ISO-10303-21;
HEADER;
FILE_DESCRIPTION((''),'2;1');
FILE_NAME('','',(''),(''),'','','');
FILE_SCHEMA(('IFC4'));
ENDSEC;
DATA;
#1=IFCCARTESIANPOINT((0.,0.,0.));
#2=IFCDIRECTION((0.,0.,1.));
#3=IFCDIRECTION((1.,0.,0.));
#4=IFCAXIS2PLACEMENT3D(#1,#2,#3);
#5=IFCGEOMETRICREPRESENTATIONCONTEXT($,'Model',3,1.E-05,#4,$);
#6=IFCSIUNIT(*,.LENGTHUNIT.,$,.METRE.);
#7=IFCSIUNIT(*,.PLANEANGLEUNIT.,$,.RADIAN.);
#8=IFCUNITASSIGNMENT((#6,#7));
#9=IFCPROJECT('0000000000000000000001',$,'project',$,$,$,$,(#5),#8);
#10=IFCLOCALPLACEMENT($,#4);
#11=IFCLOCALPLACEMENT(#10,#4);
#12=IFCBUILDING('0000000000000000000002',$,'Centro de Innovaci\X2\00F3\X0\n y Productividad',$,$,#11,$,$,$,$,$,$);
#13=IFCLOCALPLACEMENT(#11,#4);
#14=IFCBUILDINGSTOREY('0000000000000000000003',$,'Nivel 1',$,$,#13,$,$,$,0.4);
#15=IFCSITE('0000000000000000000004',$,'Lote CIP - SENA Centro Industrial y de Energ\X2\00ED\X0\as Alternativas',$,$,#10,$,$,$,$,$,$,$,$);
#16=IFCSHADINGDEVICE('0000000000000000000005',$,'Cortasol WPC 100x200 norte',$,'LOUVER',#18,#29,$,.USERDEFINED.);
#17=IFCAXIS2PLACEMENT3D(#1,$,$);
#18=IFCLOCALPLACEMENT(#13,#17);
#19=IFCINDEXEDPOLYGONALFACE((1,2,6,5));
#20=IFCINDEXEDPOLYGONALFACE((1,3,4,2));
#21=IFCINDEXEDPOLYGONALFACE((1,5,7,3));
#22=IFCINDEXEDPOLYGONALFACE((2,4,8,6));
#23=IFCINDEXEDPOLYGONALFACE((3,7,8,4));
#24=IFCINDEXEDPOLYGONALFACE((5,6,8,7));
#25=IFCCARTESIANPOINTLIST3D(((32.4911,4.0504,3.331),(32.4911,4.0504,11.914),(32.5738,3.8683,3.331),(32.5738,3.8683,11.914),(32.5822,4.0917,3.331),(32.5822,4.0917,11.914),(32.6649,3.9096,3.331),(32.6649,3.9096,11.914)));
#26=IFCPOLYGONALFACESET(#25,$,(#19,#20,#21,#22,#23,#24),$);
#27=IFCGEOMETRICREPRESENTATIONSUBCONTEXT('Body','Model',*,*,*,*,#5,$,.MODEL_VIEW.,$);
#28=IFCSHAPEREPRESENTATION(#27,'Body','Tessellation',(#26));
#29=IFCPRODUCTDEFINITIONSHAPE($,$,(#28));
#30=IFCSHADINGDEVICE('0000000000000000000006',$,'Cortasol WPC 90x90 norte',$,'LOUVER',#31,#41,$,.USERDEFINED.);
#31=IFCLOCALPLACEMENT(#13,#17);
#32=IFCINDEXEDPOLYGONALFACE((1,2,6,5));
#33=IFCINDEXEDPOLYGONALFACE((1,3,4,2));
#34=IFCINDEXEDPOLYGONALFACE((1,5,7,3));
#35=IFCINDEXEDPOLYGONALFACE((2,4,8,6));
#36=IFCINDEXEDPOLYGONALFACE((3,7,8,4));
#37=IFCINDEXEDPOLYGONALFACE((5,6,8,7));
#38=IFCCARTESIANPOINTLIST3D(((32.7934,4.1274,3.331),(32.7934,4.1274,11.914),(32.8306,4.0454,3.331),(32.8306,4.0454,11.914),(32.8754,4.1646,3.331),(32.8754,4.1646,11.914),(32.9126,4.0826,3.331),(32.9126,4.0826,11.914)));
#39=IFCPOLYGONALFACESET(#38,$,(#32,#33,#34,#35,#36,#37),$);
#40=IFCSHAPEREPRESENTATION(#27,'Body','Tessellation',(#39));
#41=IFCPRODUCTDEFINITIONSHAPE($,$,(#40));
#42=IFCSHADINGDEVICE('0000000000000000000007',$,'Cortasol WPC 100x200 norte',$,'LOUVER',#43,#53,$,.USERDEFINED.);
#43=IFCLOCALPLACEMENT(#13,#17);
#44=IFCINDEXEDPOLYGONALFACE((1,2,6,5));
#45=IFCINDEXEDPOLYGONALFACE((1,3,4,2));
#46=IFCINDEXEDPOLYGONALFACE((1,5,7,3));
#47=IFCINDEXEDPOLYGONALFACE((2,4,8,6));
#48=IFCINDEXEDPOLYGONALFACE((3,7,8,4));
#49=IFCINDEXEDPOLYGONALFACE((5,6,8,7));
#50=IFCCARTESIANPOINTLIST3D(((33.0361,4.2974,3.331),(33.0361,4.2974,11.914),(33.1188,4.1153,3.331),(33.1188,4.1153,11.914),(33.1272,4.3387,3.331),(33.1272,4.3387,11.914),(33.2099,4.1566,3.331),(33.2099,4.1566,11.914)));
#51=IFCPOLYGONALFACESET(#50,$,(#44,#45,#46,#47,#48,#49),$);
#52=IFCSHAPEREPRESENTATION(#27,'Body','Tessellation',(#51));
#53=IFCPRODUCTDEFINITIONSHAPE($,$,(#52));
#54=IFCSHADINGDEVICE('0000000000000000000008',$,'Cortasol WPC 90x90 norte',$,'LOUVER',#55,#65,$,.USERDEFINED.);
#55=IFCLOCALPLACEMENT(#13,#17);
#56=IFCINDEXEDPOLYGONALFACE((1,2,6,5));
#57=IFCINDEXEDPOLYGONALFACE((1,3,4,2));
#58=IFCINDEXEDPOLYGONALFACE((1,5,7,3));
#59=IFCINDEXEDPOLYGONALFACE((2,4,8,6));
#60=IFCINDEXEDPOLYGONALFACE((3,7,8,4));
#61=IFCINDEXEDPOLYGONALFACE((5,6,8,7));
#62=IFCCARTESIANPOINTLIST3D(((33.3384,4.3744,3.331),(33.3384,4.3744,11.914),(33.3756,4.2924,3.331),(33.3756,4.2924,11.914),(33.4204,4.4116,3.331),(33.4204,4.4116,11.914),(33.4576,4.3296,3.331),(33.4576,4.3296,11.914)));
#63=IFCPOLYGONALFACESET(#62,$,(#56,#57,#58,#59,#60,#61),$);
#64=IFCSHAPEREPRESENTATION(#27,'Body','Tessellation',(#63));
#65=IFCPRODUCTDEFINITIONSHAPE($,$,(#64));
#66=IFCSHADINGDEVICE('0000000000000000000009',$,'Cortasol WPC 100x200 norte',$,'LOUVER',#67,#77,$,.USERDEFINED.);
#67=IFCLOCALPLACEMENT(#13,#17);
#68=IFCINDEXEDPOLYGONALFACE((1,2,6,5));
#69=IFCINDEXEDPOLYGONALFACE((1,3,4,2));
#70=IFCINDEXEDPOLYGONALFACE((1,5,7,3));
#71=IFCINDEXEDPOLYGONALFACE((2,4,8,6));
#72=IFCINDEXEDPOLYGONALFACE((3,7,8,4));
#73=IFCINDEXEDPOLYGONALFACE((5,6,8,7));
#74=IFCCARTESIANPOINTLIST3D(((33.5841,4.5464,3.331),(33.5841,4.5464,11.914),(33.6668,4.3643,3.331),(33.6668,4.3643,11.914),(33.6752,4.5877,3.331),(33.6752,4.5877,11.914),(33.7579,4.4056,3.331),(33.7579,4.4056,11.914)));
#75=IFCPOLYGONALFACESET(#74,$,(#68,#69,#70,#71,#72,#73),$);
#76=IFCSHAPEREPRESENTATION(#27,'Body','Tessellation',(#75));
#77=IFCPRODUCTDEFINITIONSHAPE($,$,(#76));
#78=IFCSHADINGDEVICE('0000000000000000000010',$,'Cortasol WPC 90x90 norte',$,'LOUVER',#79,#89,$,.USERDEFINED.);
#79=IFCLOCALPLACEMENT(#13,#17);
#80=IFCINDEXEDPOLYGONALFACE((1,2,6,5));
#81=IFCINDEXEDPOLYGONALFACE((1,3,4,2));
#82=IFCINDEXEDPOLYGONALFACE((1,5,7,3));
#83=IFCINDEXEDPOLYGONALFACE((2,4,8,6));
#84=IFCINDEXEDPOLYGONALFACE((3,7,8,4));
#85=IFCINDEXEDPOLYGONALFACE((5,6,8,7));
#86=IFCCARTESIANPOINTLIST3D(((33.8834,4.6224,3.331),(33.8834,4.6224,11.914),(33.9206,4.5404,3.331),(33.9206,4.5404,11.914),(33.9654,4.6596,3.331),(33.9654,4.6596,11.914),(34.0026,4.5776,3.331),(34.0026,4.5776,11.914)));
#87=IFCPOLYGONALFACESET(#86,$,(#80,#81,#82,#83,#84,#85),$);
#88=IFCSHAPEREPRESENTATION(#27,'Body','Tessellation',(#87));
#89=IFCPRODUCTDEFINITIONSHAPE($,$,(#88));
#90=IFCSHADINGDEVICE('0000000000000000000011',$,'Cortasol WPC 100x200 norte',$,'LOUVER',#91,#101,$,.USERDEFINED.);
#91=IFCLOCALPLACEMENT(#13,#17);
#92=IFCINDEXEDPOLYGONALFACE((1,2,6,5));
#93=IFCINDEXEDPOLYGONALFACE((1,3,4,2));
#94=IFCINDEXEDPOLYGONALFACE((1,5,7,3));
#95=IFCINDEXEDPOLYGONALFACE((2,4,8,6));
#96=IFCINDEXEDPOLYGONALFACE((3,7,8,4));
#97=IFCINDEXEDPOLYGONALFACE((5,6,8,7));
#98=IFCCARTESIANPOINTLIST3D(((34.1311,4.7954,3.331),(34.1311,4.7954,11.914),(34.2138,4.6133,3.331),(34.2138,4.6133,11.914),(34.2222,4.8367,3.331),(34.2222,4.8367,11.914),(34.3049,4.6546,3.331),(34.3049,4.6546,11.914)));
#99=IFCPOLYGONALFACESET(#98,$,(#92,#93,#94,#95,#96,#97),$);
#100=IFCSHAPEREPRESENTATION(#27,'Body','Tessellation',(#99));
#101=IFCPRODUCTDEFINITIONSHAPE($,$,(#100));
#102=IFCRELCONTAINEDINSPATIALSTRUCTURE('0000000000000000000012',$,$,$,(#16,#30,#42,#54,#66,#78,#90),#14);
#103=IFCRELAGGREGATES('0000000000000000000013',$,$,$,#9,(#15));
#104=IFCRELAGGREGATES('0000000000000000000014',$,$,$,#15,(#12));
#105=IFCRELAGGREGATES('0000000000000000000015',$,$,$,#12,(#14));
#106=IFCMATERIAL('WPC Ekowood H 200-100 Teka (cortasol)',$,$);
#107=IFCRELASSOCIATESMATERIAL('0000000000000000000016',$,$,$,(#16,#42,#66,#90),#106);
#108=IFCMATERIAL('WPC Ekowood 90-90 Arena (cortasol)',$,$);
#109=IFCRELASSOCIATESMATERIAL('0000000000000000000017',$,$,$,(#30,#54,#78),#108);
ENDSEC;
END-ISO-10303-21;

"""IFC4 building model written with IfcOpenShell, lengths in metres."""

from ifc_helpers import new_model, si_unit, frame, origin_with_axes, place, context, subcontext, project, spatial, polyline, outline, extrude, material, element, save


model = new_model("IFC4")

# Units and contexts
model_context = context("Model", 3, precision=1e-05, world=origin_with_axes())
body_context = subcontext(model_context, "Body", "Model", "MODEL_VIEW")
ifc_project = project(units=[si_unit("LENGTHUNIT", "METRE"), si_unit("PLANEANGLEUNIT", "RADIAN")], contexts=[model_context])

# Site, building, storey
site_placement = place(None, origin_with_axes())
site = spatial("IfcSite", under=ifc_project, at=site_placement, Name="Lote CIP - SENA Centro Industrial y de Energías Alternativas")
building_placement = place(site_placement, origin_with_axes())
building = spatial("IfcBuilding", under=site, at=building_placement, Name="Centro de Innovación y Productividad")
storey_placement = place(building_placement, origin_with_axes())
storey = spatial("IfcBuildingStorey", under=building, at=storey_placement, Name="Nivel 1", Elevation=0.4)

# Shading devices
ifc_material_1 = material(Name="WPC Ekowood 90-90 Arena (cortasol)")
ifc_material_2 = material(Name="WPC Ekowood H 200-100 Teka (cortasol)")
shading_device_1_placement = place(storey_placement, origin_with_axes())
element("IfcShadingDevice", 1, at=shading_device_1_placement, inside=storey, material=ifc_material_2, Name="Cortasol WPC 100x200 norte", ObjectType="LOUVER", PredefinedType="USERDEFINED", context=body_context, shape_type="SweptSolid", body=[
    extrude(outline(polyline([(32.5738, 3.8683), (32.4911, 4.0504), (32.5822, 4.0917), (32.6649, 3.9096), (32.5738, 3.8683)])), frame((0.0, 0.0, 3.331)), (0.0, 0.0, 1.0), 8.583),
])
shading_device_2_placement = place(storey_placement, origin_with_axes())
element("IfcShadingDevice", 2, at=shading_device_2_placement, inside=storey, material=ifc_material_1, Name="Cortasol WPC 90x90 norte", ObjectType="LOUVER", PredefinedType="USERDEFINED", context=body_context, shape_type="SweptSolid", body=[
    extrude(outline(polyline([(32.8306, 4.0454), (32.7934, 4.1274), (32.8754, 4.1646), (32.9126, 4.0826), (32.8306, 4.0454)])), frame((0.0, 0.0, 3.331)), (0.0, 0.0, 1.0), 8.583),
])
shading_device_3_placement = place(storey_placement, origin_with_axes())
element("IfcShadingDevice", 3, at=shading_device_3_placement, inside=storey, material=ifc_material_2, Name="Cortasol WPC 100x200 norte", ObjectType="LOUVER", PredefinedType="USERDEFINED", context=body_context, shape_type="SweptSolid", body=[
    extrude(outline(polyline([(33.1188, 4.1153), (33.0361, 4.2974), (33.1272, 4.3387), (33.2099, 4.1566), (33.1188, 4.1153)])), frame((0.0, 0.0, 3.331)), (0.0, 0.0, 1.0), 8.583),
])
shading_device_4_placement = place(storey_placement, origin_with_axes())
element("IfcShadingDevice", 4, at=shading_device_4_placement, inside=storey, material=ifc_material_1, Name="Cortasol WPC 90x90 norte", ObjectType="LOUVER", PredefinedType="USERDEFINED", context=body_context, shape_type="SweptSolid", body=[
    extrude(outline(polyline([(33.3756, 4.2924), (33.3384, 4.3744), (33.4204, 4.4116), (33.4576, 4.3296), (33.3756, 4.2924)])), frame((0.0, 0.0, 3.331)), (0.0, 0.0, 1.0), 8.583),
])
shading_device_5_placement = place(storey_placement, origin_with_axes())
element("IfcShadingDevice", 5, at=shading_device_5_placement, inside=storey, material=ifc_material_2, Name="Cortasol WPC 100x200 norte", ObjectType="LOUVER", PredefinedType="USERDEFINED", context=body_context, shape_type="SweptSolid", body=[
    extrude(outline(polyline([(33.6668, 4.3643), (33.5841, 4.5464), (33.6752, 4.5877), (33.7579, 4.4056), (33.6668, 4.3643)])), frame((0.0, 0.0, 3.331)), (0.0, 0.0, 1.0), 8.583),
])
shading_device_6_placement = place(storey_placement, origin_with_axes())
element("IfcShadingDevice", 6, at=shading_device_6_placement, inside=storey, material=ifc_material_1, Name="Cortasol WPC 90x90 norte", ObjectType="LOUVER", PredefinedType="USERDEFINED", context=body_context, shape_type="SweptSolid", body=[
    extrude(outline(polyline([(33.9206, 4.5404), (33.8834, 4.6224), (33.9654, 4.6596), (34.0026, 4.5776), (33.9206, 4.5404)])), frame((0.0, 0.0, 3.331)), (0.0, 0.0, 1.0), 8.583),
])
shading_device_7_placement = place(storey_placement, origin_with_axes())
element("IfcShadingDevice", 7, at=shading_device_7_placement, inside=storey, material=ifc_material_2, Name="Cortasol WPC 100x200 norte", ObjectType="LOUVER", PredefinedType="USERDEFINED", context=body_context, shape_type="SweptSolid", body=[
    extrude(outline(polyline([(34.2138, 4.6133), (34.1311, 4.7954), (34.2222, 4.8367), (34.3049, 4.6546), (34.2138, 4.6133)])), frame((0.0, 0.0, 3.331)), (0.0, 0.0, 1.0), 8.583),
])

save(model, "model.ifc")
